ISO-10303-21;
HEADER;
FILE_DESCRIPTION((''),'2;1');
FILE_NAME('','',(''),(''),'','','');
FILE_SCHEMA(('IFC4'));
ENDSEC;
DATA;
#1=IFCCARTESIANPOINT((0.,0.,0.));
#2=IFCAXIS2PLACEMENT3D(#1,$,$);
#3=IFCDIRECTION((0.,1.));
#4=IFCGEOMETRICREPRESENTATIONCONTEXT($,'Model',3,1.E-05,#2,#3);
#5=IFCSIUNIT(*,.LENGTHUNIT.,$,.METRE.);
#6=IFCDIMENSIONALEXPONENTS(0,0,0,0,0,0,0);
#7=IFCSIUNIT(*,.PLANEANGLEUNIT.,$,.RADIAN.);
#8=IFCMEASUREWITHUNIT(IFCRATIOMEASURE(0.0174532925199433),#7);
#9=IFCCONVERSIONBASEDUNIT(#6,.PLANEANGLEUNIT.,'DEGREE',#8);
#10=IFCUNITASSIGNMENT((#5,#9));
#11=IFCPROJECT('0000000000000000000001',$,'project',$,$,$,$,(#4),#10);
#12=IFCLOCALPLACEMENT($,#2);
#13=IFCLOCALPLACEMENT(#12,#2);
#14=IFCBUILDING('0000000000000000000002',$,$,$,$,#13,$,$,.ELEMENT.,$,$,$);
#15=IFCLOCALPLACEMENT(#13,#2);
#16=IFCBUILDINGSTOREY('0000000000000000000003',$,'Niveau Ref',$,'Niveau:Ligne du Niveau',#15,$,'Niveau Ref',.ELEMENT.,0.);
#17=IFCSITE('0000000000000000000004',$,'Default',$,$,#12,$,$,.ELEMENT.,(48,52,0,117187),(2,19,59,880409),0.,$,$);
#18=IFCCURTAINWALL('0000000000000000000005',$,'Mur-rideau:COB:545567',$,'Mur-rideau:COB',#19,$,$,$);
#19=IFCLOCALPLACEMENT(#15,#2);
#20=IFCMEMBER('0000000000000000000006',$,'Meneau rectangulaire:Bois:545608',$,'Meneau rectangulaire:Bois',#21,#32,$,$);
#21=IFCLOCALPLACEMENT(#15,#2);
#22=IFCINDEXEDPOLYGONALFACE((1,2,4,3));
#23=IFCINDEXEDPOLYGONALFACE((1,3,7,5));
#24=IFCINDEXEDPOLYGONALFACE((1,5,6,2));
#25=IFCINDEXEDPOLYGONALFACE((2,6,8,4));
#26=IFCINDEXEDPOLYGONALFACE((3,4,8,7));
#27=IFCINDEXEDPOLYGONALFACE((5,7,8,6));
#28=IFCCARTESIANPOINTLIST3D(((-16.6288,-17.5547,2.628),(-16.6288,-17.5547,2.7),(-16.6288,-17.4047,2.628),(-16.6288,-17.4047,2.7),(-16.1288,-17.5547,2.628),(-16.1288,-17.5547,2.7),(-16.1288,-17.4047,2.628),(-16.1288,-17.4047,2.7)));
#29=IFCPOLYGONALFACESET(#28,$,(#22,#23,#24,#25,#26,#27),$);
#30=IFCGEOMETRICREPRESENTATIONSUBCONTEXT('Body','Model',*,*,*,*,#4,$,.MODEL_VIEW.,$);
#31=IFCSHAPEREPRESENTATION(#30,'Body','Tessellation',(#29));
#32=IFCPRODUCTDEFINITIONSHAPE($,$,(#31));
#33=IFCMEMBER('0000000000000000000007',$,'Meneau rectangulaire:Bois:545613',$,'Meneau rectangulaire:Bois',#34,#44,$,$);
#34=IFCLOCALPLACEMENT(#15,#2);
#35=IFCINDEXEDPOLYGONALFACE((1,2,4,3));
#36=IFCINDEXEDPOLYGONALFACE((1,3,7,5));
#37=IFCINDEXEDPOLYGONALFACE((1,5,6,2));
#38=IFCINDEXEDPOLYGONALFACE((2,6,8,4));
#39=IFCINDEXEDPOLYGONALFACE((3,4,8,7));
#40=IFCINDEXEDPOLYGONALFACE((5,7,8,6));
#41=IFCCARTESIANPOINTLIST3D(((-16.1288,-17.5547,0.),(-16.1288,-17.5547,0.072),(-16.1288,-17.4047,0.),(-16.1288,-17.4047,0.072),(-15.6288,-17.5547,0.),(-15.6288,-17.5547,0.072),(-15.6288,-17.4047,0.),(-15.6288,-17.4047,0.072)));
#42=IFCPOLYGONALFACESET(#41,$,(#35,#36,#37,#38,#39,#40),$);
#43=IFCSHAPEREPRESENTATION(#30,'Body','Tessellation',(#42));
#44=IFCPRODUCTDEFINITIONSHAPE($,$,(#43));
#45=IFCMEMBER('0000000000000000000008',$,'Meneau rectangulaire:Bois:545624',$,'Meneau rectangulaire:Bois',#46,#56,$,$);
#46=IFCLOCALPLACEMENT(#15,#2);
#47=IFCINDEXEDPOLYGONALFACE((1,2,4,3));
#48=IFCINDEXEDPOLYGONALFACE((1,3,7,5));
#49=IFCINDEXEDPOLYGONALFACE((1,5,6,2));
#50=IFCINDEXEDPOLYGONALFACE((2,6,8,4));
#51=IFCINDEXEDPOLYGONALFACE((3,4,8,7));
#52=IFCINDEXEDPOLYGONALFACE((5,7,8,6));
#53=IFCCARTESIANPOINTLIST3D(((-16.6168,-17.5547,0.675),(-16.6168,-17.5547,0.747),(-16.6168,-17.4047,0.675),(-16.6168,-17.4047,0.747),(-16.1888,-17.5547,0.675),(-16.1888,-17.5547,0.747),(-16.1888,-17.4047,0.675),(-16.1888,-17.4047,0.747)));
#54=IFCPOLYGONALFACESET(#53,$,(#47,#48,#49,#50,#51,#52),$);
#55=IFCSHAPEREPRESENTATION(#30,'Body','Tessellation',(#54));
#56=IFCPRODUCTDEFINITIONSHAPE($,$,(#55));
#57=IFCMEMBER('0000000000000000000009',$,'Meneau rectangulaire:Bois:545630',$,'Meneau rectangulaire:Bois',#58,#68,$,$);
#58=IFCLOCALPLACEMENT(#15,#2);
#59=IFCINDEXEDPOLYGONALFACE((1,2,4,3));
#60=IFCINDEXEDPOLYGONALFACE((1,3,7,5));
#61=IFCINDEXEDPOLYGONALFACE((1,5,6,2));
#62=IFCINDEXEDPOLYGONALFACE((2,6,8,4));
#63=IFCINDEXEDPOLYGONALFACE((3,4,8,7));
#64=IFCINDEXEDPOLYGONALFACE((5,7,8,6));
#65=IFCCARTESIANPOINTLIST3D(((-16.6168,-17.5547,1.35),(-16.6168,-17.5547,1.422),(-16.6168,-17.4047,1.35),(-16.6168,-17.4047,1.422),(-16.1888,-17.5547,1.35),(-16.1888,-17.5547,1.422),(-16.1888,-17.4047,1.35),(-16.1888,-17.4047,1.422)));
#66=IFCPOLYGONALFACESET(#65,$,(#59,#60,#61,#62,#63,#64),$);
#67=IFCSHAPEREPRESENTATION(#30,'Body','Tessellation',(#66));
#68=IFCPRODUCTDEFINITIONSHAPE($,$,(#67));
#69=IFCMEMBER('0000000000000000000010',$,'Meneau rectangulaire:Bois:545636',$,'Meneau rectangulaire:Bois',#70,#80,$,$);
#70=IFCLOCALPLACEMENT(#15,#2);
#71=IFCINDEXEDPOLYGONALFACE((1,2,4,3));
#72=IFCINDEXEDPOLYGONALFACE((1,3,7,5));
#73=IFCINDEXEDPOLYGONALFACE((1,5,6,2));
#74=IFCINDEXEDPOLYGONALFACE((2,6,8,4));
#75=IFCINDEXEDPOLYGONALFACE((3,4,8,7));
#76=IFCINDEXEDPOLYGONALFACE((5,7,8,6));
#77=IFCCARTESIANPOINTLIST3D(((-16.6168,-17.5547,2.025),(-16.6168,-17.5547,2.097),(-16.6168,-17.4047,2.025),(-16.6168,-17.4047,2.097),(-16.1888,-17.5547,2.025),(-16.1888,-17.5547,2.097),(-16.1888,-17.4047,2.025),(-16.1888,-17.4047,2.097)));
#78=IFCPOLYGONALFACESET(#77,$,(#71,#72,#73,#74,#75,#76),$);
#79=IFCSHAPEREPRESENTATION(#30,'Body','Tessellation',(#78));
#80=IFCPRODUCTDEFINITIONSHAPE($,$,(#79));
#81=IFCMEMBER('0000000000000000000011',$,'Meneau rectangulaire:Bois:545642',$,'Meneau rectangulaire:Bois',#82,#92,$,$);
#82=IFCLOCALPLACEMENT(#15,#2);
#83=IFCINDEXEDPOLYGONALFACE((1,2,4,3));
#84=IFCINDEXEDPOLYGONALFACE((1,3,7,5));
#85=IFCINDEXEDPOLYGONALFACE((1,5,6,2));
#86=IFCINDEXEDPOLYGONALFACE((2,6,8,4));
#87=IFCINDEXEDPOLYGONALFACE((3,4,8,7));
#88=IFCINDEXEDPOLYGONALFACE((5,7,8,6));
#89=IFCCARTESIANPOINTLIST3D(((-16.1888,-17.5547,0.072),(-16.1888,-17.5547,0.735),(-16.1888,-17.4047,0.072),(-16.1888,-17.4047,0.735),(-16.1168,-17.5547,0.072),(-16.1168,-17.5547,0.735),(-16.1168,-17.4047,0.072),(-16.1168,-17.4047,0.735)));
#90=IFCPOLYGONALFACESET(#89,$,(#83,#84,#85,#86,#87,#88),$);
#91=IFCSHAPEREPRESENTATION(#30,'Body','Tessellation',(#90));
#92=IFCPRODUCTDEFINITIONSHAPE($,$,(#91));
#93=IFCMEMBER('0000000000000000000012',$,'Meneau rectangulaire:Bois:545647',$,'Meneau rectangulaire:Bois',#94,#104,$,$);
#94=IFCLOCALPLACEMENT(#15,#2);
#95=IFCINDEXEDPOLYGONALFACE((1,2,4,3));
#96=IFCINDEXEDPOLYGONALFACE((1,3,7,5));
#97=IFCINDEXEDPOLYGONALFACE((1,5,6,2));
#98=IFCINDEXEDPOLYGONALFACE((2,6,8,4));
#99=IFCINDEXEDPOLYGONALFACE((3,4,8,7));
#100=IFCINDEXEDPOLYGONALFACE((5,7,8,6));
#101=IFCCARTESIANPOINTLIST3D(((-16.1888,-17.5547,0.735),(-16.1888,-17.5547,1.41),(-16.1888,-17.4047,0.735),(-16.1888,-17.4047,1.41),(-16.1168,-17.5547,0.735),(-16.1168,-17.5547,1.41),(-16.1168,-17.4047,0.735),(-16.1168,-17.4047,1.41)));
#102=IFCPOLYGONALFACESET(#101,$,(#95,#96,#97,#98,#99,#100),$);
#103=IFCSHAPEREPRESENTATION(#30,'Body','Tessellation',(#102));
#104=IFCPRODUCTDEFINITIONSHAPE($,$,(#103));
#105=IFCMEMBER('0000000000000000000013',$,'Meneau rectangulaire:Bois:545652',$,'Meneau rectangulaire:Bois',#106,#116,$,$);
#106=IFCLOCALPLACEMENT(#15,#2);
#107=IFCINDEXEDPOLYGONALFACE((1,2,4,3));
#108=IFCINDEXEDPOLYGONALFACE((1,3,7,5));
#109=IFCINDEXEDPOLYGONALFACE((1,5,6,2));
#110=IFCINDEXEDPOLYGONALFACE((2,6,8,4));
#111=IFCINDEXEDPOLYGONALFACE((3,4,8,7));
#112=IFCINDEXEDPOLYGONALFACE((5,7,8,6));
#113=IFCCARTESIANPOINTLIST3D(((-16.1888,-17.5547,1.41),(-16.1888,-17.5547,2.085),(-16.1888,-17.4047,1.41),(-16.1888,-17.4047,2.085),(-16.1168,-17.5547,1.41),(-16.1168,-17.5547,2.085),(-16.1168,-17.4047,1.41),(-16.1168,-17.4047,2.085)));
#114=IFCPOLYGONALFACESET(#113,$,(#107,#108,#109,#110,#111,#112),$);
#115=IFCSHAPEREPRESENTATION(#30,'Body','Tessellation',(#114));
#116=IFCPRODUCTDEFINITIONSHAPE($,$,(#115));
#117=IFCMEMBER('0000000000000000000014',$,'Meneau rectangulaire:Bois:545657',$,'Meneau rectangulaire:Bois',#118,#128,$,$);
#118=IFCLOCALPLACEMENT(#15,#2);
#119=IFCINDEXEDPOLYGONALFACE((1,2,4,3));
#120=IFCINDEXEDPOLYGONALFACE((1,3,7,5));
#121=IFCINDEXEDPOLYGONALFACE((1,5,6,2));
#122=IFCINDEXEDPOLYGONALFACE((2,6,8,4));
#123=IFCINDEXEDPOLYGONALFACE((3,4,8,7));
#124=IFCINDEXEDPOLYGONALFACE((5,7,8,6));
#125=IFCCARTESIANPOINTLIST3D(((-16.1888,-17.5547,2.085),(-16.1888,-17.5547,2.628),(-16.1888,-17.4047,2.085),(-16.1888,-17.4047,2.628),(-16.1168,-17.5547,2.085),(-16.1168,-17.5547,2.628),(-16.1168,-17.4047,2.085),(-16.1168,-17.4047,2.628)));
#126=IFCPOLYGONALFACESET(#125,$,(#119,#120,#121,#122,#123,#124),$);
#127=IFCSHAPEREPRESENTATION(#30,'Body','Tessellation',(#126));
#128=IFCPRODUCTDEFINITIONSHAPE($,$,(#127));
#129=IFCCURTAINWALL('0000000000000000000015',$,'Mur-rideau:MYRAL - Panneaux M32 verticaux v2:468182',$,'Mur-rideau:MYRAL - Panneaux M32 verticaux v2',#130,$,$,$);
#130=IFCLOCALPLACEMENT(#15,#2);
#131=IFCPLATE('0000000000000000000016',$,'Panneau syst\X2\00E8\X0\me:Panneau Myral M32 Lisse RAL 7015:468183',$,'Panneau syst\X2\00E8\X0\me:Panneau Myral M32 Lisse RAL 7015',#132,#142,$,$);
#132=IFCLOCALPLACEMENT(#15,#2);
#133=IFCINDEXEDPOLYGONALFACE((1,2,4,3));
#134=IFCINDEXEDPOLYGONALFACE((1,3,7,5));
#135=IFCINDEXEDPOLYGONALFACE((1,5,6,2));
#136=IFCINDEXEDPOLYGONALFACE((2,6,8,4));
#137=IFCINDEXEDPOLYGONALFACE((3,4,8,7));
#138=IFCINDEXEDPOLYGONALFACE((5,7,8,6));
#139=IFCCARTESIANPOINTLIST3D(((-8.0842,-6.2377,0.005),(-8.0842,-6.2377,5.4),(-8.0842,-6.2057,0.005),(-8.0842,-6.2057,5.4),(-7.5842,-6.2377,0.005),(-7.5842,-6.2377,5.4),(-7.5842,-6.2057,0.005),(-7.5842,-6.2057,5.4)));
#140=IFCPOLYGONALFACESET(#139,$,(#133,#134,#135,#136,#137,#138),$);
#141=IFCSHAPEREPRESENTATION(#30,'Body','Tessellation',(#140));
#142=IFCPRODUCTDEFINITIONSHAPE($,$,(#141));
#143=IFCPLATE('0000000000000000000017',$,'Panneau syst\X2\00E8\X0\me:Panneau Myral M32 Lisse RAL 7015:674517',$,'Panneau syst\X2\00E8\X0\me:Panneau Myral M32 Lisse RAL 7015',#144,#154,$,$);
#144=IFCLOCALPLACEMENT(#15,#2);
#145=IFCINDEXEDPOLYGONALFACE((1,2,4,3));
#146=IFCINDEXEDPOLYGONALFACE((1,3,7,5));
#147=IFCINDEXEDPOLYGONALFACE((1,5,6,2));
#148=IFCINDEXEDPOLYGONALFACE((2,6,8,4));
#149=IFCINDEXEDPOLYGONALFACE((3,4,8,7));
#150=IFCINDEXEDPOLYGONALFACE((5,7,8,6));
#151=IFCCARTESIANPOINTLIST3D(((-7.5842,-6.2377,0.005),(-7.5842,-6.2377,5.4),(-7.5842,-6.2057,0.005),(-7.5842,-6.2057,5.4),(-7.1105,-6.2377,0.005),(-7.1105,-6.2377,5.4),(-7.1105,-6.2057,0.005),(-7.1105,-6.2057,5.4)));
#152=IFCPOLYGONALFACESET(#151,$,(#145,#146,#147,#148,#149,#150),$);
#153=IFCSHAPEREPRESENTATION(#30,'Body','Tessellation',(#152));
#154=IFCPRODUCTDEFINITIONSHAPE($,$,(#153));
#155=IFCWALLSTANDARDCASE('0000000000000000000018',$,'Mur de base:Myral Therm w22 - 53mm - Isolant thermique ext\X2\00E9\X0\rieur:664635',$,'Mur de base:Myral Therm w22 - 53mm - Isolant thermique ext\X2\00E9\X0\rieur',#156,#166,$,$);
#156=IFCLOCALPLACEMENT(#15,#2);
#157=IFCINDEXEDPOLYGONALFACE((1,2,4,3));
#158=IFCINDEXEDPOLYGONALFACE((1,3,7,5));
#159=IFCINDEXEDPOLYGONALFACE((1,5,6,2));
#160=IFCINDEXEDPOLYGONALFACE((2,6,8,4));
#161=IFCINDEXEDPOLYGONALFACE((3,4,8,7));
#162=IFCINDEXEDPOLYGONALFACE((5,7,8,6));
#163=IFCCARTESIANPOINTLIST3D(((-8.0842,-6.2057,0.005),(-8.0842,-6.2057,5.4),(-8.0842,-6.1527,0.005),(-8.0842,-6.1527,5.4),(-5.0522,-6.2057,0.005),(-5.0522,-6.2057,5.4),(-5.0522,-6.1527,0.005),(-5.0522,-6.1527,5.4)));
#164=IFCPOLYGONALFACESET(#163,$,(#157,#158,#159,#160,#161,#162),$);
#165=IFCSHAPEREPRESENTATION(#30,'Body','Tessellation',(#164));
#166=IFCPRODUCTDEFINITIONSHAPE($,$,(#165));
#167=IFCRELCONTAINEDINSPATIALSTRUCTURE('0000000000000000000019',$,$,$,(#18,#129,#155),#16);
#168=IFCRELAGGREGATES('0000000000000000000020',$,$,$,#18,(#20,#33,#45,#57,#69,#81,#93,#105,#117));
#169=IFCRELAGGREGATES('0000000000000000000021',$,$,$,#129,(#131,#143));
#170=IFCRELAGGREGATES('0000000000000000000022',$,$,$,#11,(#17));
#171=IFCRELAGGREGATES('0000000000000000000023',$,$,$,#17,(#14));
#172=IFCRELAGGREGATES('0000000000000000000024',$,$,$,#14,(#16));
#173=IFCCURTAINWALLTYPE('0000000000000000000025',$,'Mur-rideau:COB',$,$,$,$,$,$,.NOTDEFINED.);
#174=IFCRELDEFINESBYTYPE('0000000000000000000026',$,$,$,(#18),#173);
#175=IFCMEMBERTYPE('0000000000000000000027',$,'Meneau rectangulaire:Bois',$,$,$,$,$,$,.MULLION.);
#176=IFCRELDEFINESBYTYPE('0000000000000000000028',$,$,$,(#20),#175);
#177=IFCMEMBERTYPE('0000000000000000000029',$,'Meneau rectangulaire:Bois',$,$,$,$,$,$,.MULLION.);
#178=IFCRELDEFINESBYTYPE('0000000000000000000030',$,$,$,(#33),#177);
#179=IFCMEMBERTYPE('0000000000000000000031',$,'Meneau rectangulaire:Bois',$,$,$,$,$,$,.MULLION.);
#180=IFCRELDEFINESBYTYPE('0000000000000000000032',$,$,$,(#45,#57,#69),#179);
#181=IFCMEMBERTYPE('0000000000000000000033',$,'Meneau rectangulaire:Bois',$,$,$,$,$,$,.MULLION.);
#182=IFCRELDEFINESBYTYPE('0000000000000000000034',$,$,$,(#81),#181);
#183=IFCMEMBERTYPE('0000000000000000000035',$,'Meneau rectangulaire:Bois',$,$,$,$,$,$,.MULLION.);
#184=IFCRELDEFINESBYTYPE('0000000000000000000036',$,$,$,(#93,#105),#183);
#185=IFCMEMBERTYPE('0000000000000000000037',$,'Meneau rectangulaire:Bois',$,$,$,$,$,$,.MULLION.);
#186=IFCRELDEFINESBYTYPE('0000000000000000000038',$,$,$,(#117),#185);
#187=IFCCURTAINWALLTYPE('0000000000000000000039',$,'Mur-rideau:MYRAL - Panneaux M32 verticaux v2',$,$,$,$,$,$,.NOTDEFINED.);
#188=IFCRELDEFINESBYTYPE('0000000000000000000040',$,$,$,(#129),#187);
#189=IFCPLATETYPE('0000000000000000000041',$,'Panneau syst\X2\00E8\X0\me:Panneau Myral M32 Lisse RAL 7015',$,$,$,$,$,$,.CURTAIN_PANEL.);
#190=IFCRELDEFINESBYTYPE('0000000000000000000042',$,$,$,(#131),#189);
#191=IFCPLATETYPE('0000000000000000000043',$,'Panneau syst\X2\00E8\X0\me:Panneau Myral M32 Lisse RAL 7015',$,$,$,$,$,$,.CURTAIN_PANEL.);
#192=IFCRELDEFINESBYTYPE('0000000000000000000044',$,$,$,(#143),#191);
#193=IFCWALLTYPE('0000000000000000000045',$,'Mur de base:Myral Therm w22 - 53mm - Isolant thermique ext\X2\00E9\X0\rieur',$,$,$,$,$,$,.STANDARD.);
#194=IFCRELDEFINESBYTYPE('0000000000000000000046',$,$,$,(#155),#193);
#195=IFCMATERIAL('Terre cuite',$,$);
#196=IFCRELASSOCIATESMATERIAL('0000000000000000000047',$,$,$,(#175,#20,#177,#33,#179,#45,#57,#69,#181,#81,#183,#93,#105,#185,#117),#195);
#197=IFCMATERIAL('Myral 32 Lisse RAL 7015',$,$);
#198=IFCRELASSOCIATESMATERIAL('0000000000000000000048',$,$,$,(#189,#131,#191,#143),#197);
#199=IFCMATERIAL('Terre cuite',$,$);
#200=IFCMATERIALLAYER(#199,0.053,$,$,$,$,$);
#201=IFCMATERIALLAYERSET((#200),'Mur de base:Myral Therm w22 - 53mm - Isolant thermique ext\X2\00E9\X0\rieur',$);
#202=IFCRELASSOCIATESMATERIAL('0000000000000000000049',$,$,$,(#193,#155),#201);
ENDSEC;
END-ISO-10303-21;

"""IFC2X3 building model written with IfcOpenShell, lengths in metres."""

from ifc_helpers import new_model, entity, si_unit, converted_unit, direction, frame, frame_2d, origin, origin_2d_with_axis, place, context, subcontext, project, spatial, rectangle, extrude, source, transform, mapped, material, layer, layer_set, layer_usage, type_object, type_shapes, element, aggregate, save


model = new_model("IFC2X3")

# Units and contexts
model_context = context("Model", 3, precision=1e-05, world=origin(), true_north=direction((0.0, 1.0)))
body_context = subcontext(model_context, "Body", "Model", "MODEL_VIEW")
ifc_project = project(units=[si_unit("LENGTHUNIT", "METRE"), converted_unit("PLANEANGLEUNIT", "DEGREE", entity("IfcRatioMeasure", 0.0174532925199433), si_unit("PLANEANGLEUNIT", "RADIAN"), dimensions=[0, 0, 0, 0, 0, 0, 0])], contexts=[model_context])

# Site, building, storey
site_placement = place(None, origin())
site = spatial("IfcSite", under=ifc_project, at=site_placement, Name="Default", CompositionType="ELEMENT", RefLatitude=(48, 52, 0, 117187), RefLongitude=(2, 19, 59, 880409), RefElevation=0.0)
building_placement = place(site_placement, origin())
building = spatial("IfcBuilding", under=site, at=building_placement, CompositionType="ELEMENT")
storey_placement = place(building_placement, origin())
storey = spatial("IfcBuildingStorey", under=building, at=storey_placement, Name="Niveau Ref", ObjectType="Niveau:Ligne du Niveau", LongName="Niveau Ref", CompositionType="ELEMENT", Elevation=0.0)

# Curtain wall, members
curtain_wall_type_1 = type_object("IfcCurtainWallType", Name="Mur-rideau:COB", PredefinedType="NOTDEFINED")
curtain_wall_1_placement = place(storey_placement, origin())
curtain_wall_1 = element("IfcCurtainWall", 1, at=curtain_wall_1_placement, inside=storey, type_object=curtain_wall_type_1, Name="Mur-rideau:COB:545567", ObjectType="Mur-rideau:COB")
ifc_material_1 = material(Name="Terre cuite")
member_type_1 = type_object("IfcMemberType", Name="Meneau rectangulaire:Bois", PredefinedType="MULLION", material=ifc_material_1)
shared_shape_1 = source(origin(), body_context, "Body", "SweptSolid", [
    extrude(rectangle(XDim=0.15, YDim=0.072, at=origin_2d_with_axis()), frame((-0.036, 0.0, -0.5), z_axis=(0.0, 0.0, 1.0), x_axis=(0.0, -1.0, 0.0)), (0.0, 0.0, 1.0), 0.5),
])
type_shapes(member_type_1, [shared_shape_1])
member_1_placement = place(storey_placement, frame((-16.1288, -17.4797, 2.7), z_axis=(1.0, 0.0, 0.0), x_axis=(0.0, 0.0, 1.0)))
member_1 = element("IfcMember", 2, at=member_1_placement, type_object=member_type_1, material=ifc_material_1, Name="Meneau rectangulaire:Bois:545608", ObjectType="Meneau rectangulaire:Bois", context=body_context, shape_type="MappedRepresentation", body=[
    mapped(shared_shape_1, transform((0.0, 0.0, 0.0), scale=1.0)),
])
member_type_2 = type_object("IfcMemberType", Name="Meneau rectangulaire:Bois", PredefinedType="MULLION", material=ifc_material_1)
shared_shape_2 = source(origin(), body_context, "Body", "SweptSolid", [
    extrude(rectangle(XDim=0.15, YDim=0.072, at=origin_2d_with_axis()), frame((-0.036, 0.0, -0.5), z_axis=(0.0, 0.0, 1.0), x_axis=(0.0, -1.0, 0.0)), (0.0, 0.0, 1.0), 0.5),
])
type_shapes(member_type_2, [shared_shape_2])
member_2_placement = place(storey_placement, frame((-16.1288, -17.4797, 0.0), z_axis=(-1.0, 0.0, 0.0), x_axis=(0.0, 0.0, -1.0)))
member_2 = element("IfcMember", 3, at=member_2_placement, type_object=member_type_2, material=ifc_material_1, Name="Meneau rectangulaire:Bois:545613", ObjectType="Meneau rectangulaire:Bois", context=body_context, shape_type="MappedRepresentation", body=[
    mapped(shared_shape_2, transform((0.0, 0.0, 0.0), scale=1.0)),
])
member_type_3 = type_object("IfcMemberType", Name="Meneau rectangulaire:Bois", PredefinedType="MULLION", material=ifc_material_1)
shared_shape_3 = source(origin(), body_context, "Body", "SweptSolid", [
    extrude(rectangle(XDim=0.15, YDim=0.072, at=origin_2d_with_axis()), frame((-0.024, 0.0, -0.428), z_axis=(0.0, 0.0, 1.0), x_axis=(0.0, -1.0, 0.0)), (0.0, 0.0, 1.0), 0.428),
])
type_shapes(member_type_3, [shared_shape_3])
member_3_placement = place(storey_placement, frame((-16.1888, -17.4797, 0.735), z_axis=(1.0, 0.0, 0.0), x_axis=(0.0, 0.0, 1.0)))
member_3 = element("IfcMember", 4, at=member_3_placement, type_object=member_type_3, material=ifc_material_1, Name="Meneau rectangulaire:Bois:545624", ObjectType="Meneau rectangulaire:Bois", context=body_context, shape_type="MappedRepresentation", body=[
    mapped(shared_shape_3, transform((0.0, 0.0, 0.0), scale=1.0)),
])
member_4_placement = place(storey_placement, frame((-16.1888, -17.4797, 1.41), z_axis=(1.0, 0.0, 0.0), x_axis=(0.0, 0.0, 1.0)))
member_4 = element("IfcMember", 5, at=member_4_placement, type_object=member_type_3, material=ifc_material_1, Name="Meneau rectangulaire:Bois:545630", ObjectType="Meneau rectangulaire:Bois", context=body_context, shape_type="MappedRepresentation", body=[
    mapped(shared_shape_3, transform((0.0, 0.0, 0.0), scale=1.0)),
])
member_5_placement = place(storey_placement, frame((-16.1888, -17.4797, 2.085), z_axis=(1.0, 0.0, 0.0), x_axis=(0.0, 0.0, 1.0)))
member_5 = element("IfcMember", 6, at=member_5_placement, type_object=member_type_3, material=ifc_material_1, Name="Meneau rectangulaire:Bois:545636", ObjectType="Meneau rectangulaire:Bois", context=body_context, shape_type="MappedRepresentation", body=[
    mapped(shared_shape_3, transform((0.0, 0.0, 0.0), scale=1.0)),
])
member_type_4 = type_object("IfcMemberType", Name="Meneau rectangulaire:Bois", PredefinedType="MULLION", material=ifc_material_1)
shared_shape_4 = source(origin(), body_context, "Body", "SweptSolid", [
    extrude(rectangle(XDim=0.15, YDim=0.072, at=origin_2d_with_axis()), frame((-0.024, 0.0, -0.663), z_axis=(0.0, 0.0, 1.0), x_axis=(0.0, -1.0, 0.0)), (0.0, 0.0, 1.0), 0.663),
])
type_shapes(member_type_4, [shared_shape_4])
member_6_placement = place(storey_placement, frame((-16.1288, -17.4797, 0.072), z_axis=(0.0, 0.0, -1.0), x_axis=(1.0, 0.0, 0.0)))
member_6 = element("IfcMember", 7, at=member_6_placement, type_object=member_type_4, material=ifc_material_1, Name="Meneau rectangulaire:Bois:545642", ObjectType="Meneau rectangulaire:Bois", context=body_context, shape_type="MappedRepresentation", body=[
    mapped(shared_shape_4, transform((0.0, 0.0, 0.0), scale=1.0)),
])
member_type_5 = type_object("IfcMemberType", Name="Meneau rectangulaire:Bois", PredefinedType="MULLION", material=ifc_material_1)
shared_shape_5 = source(origin(), body_context, "Body", "SweptSolid", [
    extrude(rectangle(XDim=0.15, YDim=0.072, at=origin_2d_with_axis()), frame((-0.024, 0.0, -0.675), z_axis=(0.0, 0.0, 1.0), x_axis=(0.0, -1.0, 0.0)), (0.0, 0.0, 1.0), 0.675),
])
type_shapes(member_type_5, [shared_shape_5])
member_7_placement = place(storey_placement, frame((-16.1288, -17.4797, 0.735), z_axis=(0.0, 0.0, -1.0), x_axis=(1.0, 0.0, 0.0)))
member_7 = element("IfcMember", 8, at=member_7_placement, type_object=member_type_5, material=ifc_material_1, Name="Meneau rectangulaire:Bois:545647", ObjectType="Meneau rectangulaire:Bois", context=body_context, shape_type="MappedRepresentation", body=[
    mapped(shared_shape_5, transform((0.0, 0.0, 0.0), scale=1.0)),
])
member_8_placement = place(storey_placement, frame((-16.1288, -17.4797, 1.41), z_axis=(0.0, 0.0, -1.0), x_axis=(1.0, 0.0, 0.0)))
member_8 = element("IfcMember", 9, at=member_8_placement, type_object=member_type_5, material=ifc_material_1, Name="Meneau rectangulaire:Bois:545652", ObjectType="Meneau rectangulaire:Bois", context=body_context, shape_type="MappedRepresentation", body=[
    mapped(shared_shape_5, transform((0.0, 0.0, 0.0), scale=1.0)),
])
member_type_6 = type_object("IfcMemberType", Name="Meneau rectangulaire:Bois", PredefinedType="MULLION", material=ifc_material_1)
shared_shape_6 = source(origin(), body_context, "Body", "SweptSolid", [
    extrude(rectangle(XDim=0.15, YDim=0.072, at=origin_2d_with_axis()), frame((-0.024, 0.0, -0.543), z_axis=(0.0, 0.0, 1.0), x_axis=(0.0, -1.0, 0.0)), (0.0, 0.0, 1.0), 0.543),
])
type_shapes(member_type_6, [shared_shape_6])
member_9_placement = place(storey_placement, frame((-16.1288, -17.4797, 2.085), z_axis=(0.0, 0.0, -1.0), x_axis=(1.0, 0.0, 0.0)))
member_9 = element("IfcMember", 10, at=member_9_placement, type_object=member_type_6, material=ifc_material_1, Name="Meneau rectangulaire:Bois:545657", ObjectType="Meneau rectangulaire:Bois", context=body_context, shape_type="MappedRepresentation", body=[
    mapped(shared_shape_6, transform((0.0, 0.0, 0.0), scale=1.0)),
])
aggregate(curtain_wall_1, [member_1, member_2, member_3, member_4, member_5, member_6, member_7, member_8, member_9])

# Curtain wall, plates
curtain_wall_type_2 = type_object("IfcCurtainWallType", Name="Mur-rideau:MYRAL - Panneaux M32 verticaux v2", PredefinedType="NOTDEFINED")
curtain_wall_2_placement = place(storey_placement, origin())
curtain_wall_2 = element("IfcCurtainWall", 11, at=curtain_wall_2_placement, inside=storey, type_object=curtain_wall_type_2, Name="Mur-rideau:MYRAL - Panneaux M32 verticaux v2:468182", ObjectType="Mur-rideau:MYRAL - Panneaux M32 verticaux v2")
ifc_material_2 = material(Name="Myral 32 Lisse RAL 7015")
plate_type_1 = type_object("IfcPlateType", Name="Panneau système:Panneau Myral M32 Lisse RAL 7015", PredefinedType="CURTAIN_PANEL", material=ifc_material_2)
shared_shape_7 = source(origin(), body_context, "Body", "SweptSolid", [
    extrude(rectangle(XDim=0.032, YDim=0.5, at=origin_2d_with_axis()), frame((0.0, -0.016, 0.0), z_axis=(0.0, 0.0, 1.0), x_axis=(0.0, 1.0, 0.0)), (0.0, 0.0, 1.0), 5.395),
])
type_shapes(plate_type_1, [shared_shape_7])
plate_1_placement = place(curtain_wall_2_placement, frame((-7.8342, -6.2057, 0.005)))
plate_1 = element("IfcPlate", 12, at=plate_1_placement, type_object=plate_type_1, material=ifc_material_2, Name="Panneau système:Panneau Myral M32 Lisse RAL 7015:468183", ObjectType="Panneau système:Panneau Myral M32 Lisse RAL 7015", context=body_context, shape_type="MappedRepresentation", body=[
    mapped(shared_shape_7, transform((0.0, 0.0, 0.0), scale=1.0)),
])
plate_type_2 = type_object("IfcPlateType", Name="Panneau système:Panneau Myral M32 Lisse RAL 7015", PredefinedType="CURTAIN_PANEL", material=ifc_material_2)
shared_shape_8 = source(origin(), body_context, "Body", "SweptSolid", [
    extrude(rectangle(XDim=0.032, YDim=0.4737, at=origin_2d_with_axis()), frame((0.0, -0.016, 0.0), z_axis=(0.0, 0.0, 1.0), x_axis=(0.0, 1.0, 0.0)), (0.0, 0.0, 1.0), 5.395),
])
type_shapes(plate_type_2, [shared_shape_8])
plate_2_placement = place(curtain_wall_2_placement, frame((-7.3474, -6.2057, 0.005)))
plate_2 = element("IfcPlate", 13, at=plate_2_placement, type_object=plate_type_2, material=ifc_material_2, Name="Panneau système:Panneau Myral M32 Lisse RAL 7015:674517", ObjectType="Panneau système:Panneau Myral M32 Lisse RAL 7015", context=body_context, shape_type="MappedRepresentation", body=[
    mapped(shared_shape_8, transform((0.0, 0.0, 0.0), scale=1.0)),
])
aggregate(curtain_wall_2, [plate_1, plate_2])

# Wall
ifc_material_3 = material(Name="Terre cuite")
ifc_layer = layer(ifc_material_3, 0.053)
ifc_layer_set = layer_set([ifc_layer], Name="Mur de base:Myral Therm w22 - 53mm - Isolant thermique extérieur")
ifc_layer_usage = layer_usage(ifc_layer_set, "AXIS2", "NEGATIVE", 0.0265)
wall_type = type_object("IfcWallType", Name="Mur de base:Myral Therm w22 - 53mm - Isolant thermique extérieur", PredefinedType="STANDARD", material=ifc_layer_set)
wall_placement = place(storey_placement, frame((-8.0842, -6.1792, 0.005)))
element("IfcWallStandardCase", 14, at=wall_placement, inside=storey, type_object=wall_type, material=ifc_layer_usage, Name="Mur de base:Myral Therm w22 - 53mm - Isolant thermique extérieur:664635", ObjectType="Mur de base:Myral Therm w22 - 53mm - Isolant thermique extérieur", context=body_context, shape_type="SweptSolid", body=[
    extrude(rectangle(XDim=3.032, YDim=0.053, at=frame_2d((1.516, 0.0), x_axis=(-1.0, 0.0))), origin(), (0.0, 0.0, 1.0), 5.395),
])

save(model, "model.ifc")
